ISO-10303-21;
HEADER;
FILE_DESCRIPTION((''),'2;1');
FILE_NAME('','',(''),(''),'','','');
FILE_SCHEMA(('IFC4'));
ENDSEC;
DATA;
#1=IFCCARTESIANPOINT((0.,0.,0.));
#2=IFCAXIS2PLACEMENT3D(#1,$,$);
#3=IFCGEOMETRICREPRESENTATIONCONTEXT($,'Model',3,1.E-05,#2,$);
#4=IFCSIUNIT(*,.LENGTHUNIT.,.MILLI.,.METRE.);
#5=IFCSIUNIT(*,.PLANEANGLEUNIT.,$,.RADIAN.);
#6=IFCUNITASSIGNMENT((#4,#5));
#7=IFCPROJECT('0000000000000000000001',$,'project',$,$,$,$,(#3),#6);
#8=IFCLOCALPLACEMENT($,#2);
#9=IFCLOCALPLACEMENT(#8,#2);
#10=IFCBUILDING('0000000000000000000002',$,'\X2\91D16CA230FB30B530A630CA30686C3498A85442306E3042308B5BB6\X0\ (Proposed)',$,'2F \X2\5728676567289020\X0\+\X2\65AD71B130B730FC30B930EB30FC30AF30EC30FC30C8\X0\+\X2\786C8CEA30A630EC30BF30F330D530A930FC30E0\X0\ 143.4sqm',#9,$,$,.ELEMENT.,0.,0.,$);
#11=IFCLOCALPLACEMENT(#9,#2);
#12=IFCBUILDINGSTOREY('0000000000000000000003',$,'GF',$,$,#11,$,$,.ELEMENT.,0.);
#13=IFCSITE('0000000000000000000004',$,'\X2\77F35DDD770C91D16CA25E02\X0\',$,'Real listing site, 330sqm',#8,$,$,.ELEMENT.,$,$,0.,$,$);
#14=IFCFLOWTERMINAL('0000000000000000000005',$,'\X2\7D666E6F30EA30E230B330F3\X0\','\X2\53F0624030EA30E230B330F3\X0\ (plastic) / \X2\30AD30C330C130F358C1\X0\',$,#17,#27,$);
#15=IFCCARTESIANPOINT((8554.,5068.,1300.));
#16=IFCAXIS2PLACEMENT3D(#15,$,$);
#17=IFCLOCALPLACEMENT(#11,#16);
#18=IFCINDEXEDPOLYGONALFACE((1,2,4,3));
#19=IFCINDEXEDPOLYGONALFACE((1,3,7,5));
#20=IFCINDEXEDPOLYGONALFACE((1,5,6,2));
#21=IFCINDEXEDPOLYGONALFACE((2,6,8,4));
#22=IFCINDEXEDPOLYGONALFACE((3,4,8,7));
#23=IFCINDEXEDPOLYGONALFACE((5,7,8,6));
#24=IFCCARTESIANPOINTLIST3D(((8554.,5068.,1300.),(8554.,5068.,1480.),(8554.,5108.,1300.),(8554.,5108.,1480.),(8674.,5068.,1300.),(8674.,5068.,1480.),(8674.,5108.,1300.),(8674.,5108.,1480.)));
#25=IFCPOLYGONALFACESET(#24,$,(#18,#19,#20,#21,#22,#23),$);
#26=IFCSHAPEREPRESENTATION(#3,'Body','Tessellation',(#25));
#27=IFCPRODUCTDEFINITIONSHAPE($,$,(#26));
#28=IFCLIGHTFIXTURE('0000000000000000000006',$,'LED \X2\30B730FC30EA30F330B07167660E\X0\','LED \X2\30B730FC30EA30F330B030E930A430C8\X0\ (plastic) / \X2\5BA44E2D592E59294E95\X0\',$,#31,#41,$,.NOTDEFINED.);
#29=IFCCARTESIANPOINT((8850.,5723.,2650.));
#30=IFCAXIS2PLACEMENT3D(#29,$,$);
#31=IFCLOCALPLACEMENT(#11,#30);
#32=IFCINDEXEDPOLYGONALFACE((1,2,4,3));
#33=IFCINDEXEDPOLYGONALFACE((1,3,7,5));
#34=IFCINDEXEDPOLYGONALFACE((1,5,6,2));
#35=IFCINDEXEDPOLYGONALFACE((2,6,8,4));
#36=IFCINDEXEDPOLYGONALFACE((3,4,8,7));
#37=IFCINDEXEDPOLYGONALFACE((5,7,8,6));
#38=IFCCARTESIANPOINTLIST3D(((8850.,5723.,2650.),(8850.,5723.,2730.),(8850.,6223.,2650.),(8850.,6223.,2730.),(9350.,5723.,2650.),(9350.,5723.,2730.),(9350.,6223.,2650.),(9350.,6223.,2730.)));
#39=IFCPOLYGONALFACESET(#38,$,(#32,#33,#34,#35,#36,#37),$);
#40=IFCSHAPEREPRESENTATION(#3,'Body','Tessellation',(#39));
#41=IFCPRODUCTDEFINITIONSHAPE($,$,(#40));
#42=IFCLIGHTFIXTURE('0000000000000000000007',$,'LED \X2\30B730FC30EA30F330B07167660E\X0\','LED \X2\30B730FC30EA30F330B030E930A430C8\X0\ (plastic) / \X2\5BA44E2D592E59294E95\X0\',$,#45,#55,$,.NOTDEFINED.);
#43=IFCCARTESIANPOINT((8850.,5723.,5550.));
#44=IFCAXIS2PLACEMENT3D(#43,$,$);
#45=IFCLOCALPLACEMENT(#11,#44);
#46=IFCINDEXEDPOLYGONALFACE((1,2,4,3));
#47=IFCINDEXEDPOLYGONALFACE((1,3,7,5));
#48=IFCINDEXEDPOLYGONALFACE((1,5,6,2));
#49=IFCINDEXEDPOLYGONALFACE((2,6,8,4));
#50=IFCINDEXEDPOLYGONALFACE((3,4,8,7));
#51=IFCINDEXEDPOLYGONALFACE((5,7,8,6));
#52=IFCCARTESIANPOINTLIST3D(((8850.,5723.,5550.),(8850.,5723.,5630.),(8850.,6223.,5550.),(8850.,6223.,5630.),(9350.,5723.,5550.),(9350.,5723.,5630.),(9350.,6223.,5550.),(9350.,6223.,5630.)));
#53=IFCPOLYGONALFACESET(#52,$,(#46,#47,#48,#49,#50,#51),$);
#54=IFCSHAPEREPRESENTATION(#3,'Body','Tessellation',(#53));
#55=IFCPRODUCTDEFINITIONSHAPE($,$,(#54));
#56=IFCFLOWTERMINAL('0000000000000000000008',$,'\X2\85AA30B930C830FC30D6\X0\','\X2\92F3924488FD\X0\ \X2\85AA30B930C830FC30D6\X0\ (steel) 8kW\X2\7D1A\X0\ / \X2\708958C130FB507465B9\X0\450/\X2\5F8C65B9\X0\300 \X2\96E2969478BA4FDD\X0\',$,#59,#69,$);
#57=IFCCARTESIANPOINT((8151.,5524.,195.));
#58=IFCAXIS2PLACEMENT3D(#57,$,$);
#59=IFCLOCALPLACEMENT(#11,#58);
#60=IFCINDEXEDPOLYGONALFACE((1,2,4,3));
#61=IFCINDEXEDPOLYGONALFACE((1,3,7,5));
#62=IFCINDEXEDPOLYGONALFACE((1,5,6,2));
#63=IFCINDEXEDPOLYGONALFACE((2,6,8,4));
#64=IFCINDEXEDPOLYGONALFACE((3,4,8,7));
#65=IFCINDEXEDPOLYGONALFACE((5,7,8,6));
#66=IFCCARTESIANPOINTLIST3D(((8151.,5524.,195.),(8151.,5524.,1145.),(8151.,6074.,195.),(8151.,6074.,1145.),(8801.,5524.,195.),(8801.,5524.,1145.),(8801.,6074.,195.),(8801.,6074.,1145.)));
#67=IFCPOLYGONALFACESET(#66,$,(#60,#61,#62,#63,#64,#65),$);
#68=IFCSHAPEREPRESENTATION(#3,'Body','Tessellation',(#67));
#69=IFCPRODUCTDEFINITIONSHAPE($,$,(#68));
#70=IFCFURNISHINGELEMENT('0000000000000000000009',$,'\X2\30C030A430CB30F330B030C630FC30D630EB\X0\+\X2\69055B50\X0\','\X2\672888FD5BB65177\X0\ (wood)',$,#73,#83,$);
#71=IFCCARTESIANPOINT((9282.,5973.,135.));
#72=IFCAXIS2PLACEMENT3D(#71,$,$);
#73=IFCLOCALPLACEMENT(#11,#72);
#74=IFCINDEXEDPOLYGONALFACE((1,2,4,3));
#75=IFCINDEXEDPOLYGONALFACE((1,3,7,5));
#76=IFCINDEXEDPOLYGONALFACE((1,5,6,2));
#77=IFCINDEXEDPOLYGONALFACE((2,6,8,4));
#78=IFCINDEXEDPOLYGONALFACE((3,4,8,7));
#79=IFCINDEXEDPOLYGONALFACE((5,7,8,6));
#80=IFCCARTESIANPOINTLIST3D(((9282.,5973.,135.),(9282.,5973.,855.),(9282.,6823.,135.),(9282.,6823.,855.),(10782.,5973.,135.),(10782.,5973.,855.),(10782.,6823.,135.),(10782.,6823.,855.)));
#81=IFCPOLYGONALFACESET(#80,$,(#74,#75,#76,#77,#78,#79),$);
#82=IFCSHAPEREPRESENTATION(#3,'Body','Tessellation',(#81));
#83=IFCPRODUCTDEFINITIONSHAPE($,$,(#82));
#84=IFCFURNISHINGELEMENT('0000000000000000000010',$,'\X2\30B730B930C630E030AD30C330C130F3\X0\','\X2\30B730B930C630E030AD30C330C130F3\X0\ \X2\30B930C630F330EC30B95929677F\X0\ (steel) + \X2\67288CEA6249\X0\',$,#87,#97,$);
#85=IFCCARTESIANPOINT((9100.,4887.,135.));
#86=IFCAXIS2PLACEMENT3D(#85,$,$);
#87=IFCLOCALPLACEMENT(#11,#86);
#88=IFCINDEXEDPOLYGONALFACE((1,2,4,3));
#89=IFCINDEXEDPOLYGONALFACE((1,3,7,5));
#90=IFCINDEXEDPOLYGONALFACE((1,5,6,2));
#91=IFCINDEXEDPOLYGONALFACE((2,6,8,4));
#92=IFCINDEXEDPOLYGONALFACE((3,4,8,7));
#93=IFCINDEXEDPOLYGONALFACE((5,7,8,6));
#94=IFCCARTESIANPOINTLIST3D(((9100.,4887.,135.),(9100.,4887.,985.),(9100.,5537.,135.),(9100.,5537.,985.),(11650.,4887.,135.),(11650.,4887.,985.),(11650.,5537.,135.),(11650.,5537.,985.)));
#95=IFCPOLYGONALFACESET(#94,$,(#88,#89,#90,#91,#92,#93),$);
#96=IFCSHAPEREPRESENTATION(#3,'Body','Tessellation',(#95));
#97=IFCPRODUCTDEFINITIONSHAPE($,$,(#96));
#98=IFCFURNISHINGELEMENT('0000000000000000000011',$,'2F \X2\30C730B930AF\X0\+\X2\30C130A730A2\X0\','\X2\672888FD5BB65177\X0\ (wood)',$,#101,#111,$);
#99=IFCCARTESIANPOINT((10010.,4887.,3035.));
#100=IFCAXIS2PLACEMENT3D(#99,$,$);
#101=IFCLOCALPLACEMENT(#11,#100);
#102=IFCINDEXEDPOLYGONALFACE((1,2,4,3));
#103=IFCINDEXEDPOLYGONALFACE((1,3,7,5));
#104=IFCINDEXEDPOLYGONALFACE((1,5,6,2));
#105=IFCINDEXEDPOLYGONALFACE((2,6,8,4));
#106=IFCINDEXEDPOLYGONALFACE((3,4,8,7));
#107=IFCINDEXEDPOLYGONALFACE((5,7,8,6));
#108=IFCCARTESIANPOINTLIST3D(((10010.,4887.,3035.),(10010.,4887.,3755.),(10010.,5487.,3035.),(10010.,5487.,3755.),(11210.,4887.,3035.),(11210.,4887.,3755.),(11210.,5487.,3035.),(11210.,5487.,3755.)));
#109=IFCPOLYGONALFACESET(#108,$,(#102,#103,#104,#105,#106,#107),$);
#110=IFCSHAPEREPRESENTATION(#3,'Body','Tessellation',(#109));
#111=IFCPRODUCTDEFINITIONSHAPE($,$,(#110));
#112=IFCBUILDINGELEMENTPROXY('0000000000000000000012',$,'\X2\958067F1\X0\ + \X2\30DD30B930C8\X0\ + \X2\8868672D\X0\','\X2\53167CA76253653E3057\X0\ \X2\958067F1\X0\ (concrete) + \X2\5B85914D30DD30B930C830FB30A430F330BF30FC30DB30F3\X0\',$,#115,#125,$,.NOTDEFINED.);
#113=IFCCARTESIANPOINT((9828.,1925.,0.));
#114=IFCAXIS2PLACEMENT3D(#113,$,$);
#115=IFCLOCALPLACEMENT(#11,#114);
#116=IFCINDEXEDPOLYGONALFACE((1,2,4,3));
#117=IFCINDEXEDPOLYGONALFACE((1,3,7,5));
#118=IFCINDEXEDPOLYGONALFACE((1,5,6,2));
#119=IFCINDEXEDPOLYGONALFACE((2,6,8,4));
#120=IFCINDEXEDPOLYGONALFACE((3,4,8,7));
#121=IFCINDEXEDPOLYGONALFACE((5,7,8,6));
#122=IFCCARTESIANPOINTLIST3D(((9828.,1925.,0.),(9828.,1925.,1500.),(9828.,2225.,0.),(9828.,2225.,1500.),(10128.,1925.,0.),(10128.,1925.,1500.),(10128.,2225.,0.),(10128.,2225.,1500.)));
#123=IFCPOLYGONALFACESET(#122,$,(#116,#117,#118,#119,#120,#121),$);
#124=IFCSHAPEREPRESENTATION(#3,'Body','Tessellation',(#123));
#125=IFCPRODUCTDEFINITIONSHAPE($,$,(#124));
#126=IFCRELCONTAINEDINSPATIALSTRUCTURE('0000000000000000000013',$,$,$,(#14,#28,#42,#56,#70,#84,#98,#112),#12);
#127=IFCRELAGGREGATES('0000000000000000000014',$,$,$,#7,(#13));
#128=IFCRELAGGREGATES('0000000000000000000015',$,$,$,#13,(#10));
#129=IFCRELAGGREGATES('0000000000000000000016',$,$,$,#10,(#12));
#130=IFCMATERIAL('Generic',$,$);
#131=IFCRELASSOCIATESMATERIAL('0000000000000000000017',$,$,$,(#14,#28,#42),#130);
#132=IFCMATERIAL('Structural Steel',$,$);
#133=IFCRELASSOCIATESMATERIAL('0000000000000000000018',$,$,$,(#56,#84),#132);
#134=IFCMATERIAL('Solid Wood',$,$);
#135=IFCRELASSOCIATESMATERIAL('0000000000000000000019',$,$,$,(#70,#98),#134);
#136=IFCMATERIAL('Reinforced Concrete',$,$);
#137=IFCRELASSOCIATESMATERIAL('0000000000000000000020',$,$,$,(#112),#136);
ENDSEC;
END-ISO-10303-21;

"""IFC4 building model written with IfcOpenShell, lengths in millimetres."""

from ifc_helpers import new_model, si_unit, frame, frame_2d, origin, place, context, project, spatial, rectangle, extrude, material, element, save


model = new_model("IFC4")

# Units and contexts
model_context = context("Model", 3, precision=1e-05, world=origin())
ifc_project = project(units=[si_unit("LENGTHUNIT", "METRE", prefix="MILLI"), si_unit("PLANEANGLEUNIT", "RADIAN")], contexts=[model_context])

# Site, building, storey
site_placement = place(None, origin())
site = spatial("IfcSite", under=ifc_project, at=site_placement, Name="石川県金沢市", ObjectType="Real listing site, 330sqm", CompositionType="ELEMENT", RefElevation=0.0)
building_placement = place(site_placement, origin())
building = spatial("IfcBuilding", under=site, at=building_placement, Name="金沢・サウナと水風呂のある家 (Proposed)", ObjectType="2F 在来木造+断熱シースルークレート+硬質ウレタンフォーム 143.4sqm", CompositionType="ELEMENT", ElevationOfRefHeight=0.0, ElevationOfTerrain=0.0)
storey_placement = place(building_placement, origin())
storey = spatial("IfcBuildingStorey", under=building, at=storey_placement, Name="GF", CompositionType="ELEMENT", Elevation=0.0)

# Shared definitions
ifc_material_1 = material(Name="Solid Wood")

# Shared definitions
ifc_material_2 = material(Name="Structural Steel")

# Shared definitions
ifc_material_3 = material(Name="Reinforced Concrete")

# Flow terminal
ifc_material_4 = material(Name="Generic")
flow_terminal_1_placement = place(storey_placement, frame((8554.0, 5068.0, 1300.0)))
element("IfcFlowTerminal", 1, at=flow_terminal_1_placement, inside=storey, material=ifc_material_4, Name="給湯リモコン", Description="台所リモコン (plastic) / キッチン壁", context=model_context, shape_type="SweptSolid", body=[
    extrude(rectangle(XDim=120.0, YDim=40.0, at=frame_2d((60.0, 20.0))), frame((8554.0, 5068.0, 1300.0)), (0.0, 0.0, 1.0), 180.0),
])

# Light fixtures
light_fixture_1_placement = place(storey_placement, frame((8850.0, 5723.0, 2650.0)))
element("IfcLightFixture", 2, at=light_fixture_1_placement, inside=storey, material=ifc_material_4, Name="LED シーリング照明", Description="LED シーリングライト (plastic) / 室中央天井", PredefinedType="NOTDEFINED", context=model_context, shape_type="SweptSolid", body=[
    extrude(rectangle(XDim=500.0, YDim=500.0, at=frame_2d((250.0, 250.0))), frame((8850.0, 5723.0, 2650.0)), (0.0, 0.0, 1.0), 80.0),
])
light_fixture_2_placement = place(storey_placement, frame((8850.0, 5723.0, 5550.0)))
element("IfcLightFixture", 3, at=light_fixture_2_placement, inside=storey, material=ifc_material_4, Name="LED シーリング照明", Description="LED シーリングライト (plastic) / 室中央天井", PredefinedType="NOTDEFINED", context=model_context, shape_type="SweptSolid", body=[
    extrude(rectangle(XDim=500.0, YDim=500.0, at=frame_2d((250.0, 250.0))), frame((8850.0, 5723.0, 5550.0)), (0.0, 0.0, 1.0), 80.0),
])

# Flow terminal
flow_terminal_2_placement = place(storey_placement, frame((8151.0, 5524.0, 195.0)))
element("IfcFlowTerminal", 4, at=flow_terminal_2_placement, inside=storey, material=ifc_material_2, Name="薪ストーブ", Description="鋳鉄製 薪ストーブ (steel) 8kW級 / 炉壁・側方450/後方300 離隔確保", context=model_context, shape_type="SweptSolid", body=[
    extrude(rectangle(XDim=650.0, YDim=550.0, at=frame_2d((325.0, 275.0))), frame((8151.0, 5524.0, 195.0)), (0.0, 0.0, 1.0), 950.0),
])

# Furnishing elements
furnishing_1_placement = place(storey_placement, frame((9282.0, 5973.0, 135.0)))
element("IfcFurnishingElement", 5, at=furnishing_1_placement, inside=storey, material=ifc_material_1, Name="ダイニングテーブル+椅子", Description="木製家具 (wood)", context=model_context, shape_type="SweptSolid", body=[
    extrude(rectangle(XDim=1500.0, YDim=850.0, at=frame_2d((750.0, 425.0))), frame((9282.0, 5973.0, 135.0)), (0.0, 0.0, 1.0), 720.0),
])
furnishing_2_placement = place(storey_placement, frame((9100.0, 4887.0, 135.0)))
element("IfcFurnishingElement", 6, at=furnishing_2_placement, inside=storey, material=ifc_material_2, Name="システムキッチン", Description="システムキッチン ステンレス天板 (steel) + 木質扉", context=model_context, shape_type="SweptSolid", body=[
    extrude(rectangle(XDim=2550.0, YDim=650.0, at=frame_2d((1275.0, 325.0))), frame((9100.0, 4887.0, 135.0)), (0.0, 0.0, 1.0), 850.0),
])
furnishing_3_placement = place(storey_placement, frame((10010.0, 4887.0, 3035.0)))
element("IfcFurnishingElement", 7, at=furnishing_3_placement, inside=storey, material=ifc_material_1, Name="2F デスク+チェア", Description="木製家具 (wood)", context=model_context, shape_type="SweptSolid", body=[
    extrude(rectangle(XDim=1200.0, YDim=600.0, at=frame_2d((600.0, 300.0))), frame((10010.0, 4887.0, 3035.0)), (0.0, 0.0, 1.0), 720.0),
])

# Building element proxy
proxy_placement = place(storey_placement, frame((9828.0, 1925.0, 0.0)))
element("IfcBuildingElementProxy", 8, at=proxy_placement, inside=storey, material=ifc_material_3, Name="門柱 + ポスト + 表札", Description="化粧打放し 門柱 (concrete) + 宅配ポスト・インターホン", PredefinedType="NOTDEFINED", context=model_context, shape_type="SweptSolid", body=[
    extrude(rectangle(XDim=300.0, YDim=300.0, at=frame_2d((150.0, 150.0))), frame((9828.0, 1925.0, 0.0)), (0.0, 0.0, 1.0), 1500.0),
])

save(model, "model.ifc")
